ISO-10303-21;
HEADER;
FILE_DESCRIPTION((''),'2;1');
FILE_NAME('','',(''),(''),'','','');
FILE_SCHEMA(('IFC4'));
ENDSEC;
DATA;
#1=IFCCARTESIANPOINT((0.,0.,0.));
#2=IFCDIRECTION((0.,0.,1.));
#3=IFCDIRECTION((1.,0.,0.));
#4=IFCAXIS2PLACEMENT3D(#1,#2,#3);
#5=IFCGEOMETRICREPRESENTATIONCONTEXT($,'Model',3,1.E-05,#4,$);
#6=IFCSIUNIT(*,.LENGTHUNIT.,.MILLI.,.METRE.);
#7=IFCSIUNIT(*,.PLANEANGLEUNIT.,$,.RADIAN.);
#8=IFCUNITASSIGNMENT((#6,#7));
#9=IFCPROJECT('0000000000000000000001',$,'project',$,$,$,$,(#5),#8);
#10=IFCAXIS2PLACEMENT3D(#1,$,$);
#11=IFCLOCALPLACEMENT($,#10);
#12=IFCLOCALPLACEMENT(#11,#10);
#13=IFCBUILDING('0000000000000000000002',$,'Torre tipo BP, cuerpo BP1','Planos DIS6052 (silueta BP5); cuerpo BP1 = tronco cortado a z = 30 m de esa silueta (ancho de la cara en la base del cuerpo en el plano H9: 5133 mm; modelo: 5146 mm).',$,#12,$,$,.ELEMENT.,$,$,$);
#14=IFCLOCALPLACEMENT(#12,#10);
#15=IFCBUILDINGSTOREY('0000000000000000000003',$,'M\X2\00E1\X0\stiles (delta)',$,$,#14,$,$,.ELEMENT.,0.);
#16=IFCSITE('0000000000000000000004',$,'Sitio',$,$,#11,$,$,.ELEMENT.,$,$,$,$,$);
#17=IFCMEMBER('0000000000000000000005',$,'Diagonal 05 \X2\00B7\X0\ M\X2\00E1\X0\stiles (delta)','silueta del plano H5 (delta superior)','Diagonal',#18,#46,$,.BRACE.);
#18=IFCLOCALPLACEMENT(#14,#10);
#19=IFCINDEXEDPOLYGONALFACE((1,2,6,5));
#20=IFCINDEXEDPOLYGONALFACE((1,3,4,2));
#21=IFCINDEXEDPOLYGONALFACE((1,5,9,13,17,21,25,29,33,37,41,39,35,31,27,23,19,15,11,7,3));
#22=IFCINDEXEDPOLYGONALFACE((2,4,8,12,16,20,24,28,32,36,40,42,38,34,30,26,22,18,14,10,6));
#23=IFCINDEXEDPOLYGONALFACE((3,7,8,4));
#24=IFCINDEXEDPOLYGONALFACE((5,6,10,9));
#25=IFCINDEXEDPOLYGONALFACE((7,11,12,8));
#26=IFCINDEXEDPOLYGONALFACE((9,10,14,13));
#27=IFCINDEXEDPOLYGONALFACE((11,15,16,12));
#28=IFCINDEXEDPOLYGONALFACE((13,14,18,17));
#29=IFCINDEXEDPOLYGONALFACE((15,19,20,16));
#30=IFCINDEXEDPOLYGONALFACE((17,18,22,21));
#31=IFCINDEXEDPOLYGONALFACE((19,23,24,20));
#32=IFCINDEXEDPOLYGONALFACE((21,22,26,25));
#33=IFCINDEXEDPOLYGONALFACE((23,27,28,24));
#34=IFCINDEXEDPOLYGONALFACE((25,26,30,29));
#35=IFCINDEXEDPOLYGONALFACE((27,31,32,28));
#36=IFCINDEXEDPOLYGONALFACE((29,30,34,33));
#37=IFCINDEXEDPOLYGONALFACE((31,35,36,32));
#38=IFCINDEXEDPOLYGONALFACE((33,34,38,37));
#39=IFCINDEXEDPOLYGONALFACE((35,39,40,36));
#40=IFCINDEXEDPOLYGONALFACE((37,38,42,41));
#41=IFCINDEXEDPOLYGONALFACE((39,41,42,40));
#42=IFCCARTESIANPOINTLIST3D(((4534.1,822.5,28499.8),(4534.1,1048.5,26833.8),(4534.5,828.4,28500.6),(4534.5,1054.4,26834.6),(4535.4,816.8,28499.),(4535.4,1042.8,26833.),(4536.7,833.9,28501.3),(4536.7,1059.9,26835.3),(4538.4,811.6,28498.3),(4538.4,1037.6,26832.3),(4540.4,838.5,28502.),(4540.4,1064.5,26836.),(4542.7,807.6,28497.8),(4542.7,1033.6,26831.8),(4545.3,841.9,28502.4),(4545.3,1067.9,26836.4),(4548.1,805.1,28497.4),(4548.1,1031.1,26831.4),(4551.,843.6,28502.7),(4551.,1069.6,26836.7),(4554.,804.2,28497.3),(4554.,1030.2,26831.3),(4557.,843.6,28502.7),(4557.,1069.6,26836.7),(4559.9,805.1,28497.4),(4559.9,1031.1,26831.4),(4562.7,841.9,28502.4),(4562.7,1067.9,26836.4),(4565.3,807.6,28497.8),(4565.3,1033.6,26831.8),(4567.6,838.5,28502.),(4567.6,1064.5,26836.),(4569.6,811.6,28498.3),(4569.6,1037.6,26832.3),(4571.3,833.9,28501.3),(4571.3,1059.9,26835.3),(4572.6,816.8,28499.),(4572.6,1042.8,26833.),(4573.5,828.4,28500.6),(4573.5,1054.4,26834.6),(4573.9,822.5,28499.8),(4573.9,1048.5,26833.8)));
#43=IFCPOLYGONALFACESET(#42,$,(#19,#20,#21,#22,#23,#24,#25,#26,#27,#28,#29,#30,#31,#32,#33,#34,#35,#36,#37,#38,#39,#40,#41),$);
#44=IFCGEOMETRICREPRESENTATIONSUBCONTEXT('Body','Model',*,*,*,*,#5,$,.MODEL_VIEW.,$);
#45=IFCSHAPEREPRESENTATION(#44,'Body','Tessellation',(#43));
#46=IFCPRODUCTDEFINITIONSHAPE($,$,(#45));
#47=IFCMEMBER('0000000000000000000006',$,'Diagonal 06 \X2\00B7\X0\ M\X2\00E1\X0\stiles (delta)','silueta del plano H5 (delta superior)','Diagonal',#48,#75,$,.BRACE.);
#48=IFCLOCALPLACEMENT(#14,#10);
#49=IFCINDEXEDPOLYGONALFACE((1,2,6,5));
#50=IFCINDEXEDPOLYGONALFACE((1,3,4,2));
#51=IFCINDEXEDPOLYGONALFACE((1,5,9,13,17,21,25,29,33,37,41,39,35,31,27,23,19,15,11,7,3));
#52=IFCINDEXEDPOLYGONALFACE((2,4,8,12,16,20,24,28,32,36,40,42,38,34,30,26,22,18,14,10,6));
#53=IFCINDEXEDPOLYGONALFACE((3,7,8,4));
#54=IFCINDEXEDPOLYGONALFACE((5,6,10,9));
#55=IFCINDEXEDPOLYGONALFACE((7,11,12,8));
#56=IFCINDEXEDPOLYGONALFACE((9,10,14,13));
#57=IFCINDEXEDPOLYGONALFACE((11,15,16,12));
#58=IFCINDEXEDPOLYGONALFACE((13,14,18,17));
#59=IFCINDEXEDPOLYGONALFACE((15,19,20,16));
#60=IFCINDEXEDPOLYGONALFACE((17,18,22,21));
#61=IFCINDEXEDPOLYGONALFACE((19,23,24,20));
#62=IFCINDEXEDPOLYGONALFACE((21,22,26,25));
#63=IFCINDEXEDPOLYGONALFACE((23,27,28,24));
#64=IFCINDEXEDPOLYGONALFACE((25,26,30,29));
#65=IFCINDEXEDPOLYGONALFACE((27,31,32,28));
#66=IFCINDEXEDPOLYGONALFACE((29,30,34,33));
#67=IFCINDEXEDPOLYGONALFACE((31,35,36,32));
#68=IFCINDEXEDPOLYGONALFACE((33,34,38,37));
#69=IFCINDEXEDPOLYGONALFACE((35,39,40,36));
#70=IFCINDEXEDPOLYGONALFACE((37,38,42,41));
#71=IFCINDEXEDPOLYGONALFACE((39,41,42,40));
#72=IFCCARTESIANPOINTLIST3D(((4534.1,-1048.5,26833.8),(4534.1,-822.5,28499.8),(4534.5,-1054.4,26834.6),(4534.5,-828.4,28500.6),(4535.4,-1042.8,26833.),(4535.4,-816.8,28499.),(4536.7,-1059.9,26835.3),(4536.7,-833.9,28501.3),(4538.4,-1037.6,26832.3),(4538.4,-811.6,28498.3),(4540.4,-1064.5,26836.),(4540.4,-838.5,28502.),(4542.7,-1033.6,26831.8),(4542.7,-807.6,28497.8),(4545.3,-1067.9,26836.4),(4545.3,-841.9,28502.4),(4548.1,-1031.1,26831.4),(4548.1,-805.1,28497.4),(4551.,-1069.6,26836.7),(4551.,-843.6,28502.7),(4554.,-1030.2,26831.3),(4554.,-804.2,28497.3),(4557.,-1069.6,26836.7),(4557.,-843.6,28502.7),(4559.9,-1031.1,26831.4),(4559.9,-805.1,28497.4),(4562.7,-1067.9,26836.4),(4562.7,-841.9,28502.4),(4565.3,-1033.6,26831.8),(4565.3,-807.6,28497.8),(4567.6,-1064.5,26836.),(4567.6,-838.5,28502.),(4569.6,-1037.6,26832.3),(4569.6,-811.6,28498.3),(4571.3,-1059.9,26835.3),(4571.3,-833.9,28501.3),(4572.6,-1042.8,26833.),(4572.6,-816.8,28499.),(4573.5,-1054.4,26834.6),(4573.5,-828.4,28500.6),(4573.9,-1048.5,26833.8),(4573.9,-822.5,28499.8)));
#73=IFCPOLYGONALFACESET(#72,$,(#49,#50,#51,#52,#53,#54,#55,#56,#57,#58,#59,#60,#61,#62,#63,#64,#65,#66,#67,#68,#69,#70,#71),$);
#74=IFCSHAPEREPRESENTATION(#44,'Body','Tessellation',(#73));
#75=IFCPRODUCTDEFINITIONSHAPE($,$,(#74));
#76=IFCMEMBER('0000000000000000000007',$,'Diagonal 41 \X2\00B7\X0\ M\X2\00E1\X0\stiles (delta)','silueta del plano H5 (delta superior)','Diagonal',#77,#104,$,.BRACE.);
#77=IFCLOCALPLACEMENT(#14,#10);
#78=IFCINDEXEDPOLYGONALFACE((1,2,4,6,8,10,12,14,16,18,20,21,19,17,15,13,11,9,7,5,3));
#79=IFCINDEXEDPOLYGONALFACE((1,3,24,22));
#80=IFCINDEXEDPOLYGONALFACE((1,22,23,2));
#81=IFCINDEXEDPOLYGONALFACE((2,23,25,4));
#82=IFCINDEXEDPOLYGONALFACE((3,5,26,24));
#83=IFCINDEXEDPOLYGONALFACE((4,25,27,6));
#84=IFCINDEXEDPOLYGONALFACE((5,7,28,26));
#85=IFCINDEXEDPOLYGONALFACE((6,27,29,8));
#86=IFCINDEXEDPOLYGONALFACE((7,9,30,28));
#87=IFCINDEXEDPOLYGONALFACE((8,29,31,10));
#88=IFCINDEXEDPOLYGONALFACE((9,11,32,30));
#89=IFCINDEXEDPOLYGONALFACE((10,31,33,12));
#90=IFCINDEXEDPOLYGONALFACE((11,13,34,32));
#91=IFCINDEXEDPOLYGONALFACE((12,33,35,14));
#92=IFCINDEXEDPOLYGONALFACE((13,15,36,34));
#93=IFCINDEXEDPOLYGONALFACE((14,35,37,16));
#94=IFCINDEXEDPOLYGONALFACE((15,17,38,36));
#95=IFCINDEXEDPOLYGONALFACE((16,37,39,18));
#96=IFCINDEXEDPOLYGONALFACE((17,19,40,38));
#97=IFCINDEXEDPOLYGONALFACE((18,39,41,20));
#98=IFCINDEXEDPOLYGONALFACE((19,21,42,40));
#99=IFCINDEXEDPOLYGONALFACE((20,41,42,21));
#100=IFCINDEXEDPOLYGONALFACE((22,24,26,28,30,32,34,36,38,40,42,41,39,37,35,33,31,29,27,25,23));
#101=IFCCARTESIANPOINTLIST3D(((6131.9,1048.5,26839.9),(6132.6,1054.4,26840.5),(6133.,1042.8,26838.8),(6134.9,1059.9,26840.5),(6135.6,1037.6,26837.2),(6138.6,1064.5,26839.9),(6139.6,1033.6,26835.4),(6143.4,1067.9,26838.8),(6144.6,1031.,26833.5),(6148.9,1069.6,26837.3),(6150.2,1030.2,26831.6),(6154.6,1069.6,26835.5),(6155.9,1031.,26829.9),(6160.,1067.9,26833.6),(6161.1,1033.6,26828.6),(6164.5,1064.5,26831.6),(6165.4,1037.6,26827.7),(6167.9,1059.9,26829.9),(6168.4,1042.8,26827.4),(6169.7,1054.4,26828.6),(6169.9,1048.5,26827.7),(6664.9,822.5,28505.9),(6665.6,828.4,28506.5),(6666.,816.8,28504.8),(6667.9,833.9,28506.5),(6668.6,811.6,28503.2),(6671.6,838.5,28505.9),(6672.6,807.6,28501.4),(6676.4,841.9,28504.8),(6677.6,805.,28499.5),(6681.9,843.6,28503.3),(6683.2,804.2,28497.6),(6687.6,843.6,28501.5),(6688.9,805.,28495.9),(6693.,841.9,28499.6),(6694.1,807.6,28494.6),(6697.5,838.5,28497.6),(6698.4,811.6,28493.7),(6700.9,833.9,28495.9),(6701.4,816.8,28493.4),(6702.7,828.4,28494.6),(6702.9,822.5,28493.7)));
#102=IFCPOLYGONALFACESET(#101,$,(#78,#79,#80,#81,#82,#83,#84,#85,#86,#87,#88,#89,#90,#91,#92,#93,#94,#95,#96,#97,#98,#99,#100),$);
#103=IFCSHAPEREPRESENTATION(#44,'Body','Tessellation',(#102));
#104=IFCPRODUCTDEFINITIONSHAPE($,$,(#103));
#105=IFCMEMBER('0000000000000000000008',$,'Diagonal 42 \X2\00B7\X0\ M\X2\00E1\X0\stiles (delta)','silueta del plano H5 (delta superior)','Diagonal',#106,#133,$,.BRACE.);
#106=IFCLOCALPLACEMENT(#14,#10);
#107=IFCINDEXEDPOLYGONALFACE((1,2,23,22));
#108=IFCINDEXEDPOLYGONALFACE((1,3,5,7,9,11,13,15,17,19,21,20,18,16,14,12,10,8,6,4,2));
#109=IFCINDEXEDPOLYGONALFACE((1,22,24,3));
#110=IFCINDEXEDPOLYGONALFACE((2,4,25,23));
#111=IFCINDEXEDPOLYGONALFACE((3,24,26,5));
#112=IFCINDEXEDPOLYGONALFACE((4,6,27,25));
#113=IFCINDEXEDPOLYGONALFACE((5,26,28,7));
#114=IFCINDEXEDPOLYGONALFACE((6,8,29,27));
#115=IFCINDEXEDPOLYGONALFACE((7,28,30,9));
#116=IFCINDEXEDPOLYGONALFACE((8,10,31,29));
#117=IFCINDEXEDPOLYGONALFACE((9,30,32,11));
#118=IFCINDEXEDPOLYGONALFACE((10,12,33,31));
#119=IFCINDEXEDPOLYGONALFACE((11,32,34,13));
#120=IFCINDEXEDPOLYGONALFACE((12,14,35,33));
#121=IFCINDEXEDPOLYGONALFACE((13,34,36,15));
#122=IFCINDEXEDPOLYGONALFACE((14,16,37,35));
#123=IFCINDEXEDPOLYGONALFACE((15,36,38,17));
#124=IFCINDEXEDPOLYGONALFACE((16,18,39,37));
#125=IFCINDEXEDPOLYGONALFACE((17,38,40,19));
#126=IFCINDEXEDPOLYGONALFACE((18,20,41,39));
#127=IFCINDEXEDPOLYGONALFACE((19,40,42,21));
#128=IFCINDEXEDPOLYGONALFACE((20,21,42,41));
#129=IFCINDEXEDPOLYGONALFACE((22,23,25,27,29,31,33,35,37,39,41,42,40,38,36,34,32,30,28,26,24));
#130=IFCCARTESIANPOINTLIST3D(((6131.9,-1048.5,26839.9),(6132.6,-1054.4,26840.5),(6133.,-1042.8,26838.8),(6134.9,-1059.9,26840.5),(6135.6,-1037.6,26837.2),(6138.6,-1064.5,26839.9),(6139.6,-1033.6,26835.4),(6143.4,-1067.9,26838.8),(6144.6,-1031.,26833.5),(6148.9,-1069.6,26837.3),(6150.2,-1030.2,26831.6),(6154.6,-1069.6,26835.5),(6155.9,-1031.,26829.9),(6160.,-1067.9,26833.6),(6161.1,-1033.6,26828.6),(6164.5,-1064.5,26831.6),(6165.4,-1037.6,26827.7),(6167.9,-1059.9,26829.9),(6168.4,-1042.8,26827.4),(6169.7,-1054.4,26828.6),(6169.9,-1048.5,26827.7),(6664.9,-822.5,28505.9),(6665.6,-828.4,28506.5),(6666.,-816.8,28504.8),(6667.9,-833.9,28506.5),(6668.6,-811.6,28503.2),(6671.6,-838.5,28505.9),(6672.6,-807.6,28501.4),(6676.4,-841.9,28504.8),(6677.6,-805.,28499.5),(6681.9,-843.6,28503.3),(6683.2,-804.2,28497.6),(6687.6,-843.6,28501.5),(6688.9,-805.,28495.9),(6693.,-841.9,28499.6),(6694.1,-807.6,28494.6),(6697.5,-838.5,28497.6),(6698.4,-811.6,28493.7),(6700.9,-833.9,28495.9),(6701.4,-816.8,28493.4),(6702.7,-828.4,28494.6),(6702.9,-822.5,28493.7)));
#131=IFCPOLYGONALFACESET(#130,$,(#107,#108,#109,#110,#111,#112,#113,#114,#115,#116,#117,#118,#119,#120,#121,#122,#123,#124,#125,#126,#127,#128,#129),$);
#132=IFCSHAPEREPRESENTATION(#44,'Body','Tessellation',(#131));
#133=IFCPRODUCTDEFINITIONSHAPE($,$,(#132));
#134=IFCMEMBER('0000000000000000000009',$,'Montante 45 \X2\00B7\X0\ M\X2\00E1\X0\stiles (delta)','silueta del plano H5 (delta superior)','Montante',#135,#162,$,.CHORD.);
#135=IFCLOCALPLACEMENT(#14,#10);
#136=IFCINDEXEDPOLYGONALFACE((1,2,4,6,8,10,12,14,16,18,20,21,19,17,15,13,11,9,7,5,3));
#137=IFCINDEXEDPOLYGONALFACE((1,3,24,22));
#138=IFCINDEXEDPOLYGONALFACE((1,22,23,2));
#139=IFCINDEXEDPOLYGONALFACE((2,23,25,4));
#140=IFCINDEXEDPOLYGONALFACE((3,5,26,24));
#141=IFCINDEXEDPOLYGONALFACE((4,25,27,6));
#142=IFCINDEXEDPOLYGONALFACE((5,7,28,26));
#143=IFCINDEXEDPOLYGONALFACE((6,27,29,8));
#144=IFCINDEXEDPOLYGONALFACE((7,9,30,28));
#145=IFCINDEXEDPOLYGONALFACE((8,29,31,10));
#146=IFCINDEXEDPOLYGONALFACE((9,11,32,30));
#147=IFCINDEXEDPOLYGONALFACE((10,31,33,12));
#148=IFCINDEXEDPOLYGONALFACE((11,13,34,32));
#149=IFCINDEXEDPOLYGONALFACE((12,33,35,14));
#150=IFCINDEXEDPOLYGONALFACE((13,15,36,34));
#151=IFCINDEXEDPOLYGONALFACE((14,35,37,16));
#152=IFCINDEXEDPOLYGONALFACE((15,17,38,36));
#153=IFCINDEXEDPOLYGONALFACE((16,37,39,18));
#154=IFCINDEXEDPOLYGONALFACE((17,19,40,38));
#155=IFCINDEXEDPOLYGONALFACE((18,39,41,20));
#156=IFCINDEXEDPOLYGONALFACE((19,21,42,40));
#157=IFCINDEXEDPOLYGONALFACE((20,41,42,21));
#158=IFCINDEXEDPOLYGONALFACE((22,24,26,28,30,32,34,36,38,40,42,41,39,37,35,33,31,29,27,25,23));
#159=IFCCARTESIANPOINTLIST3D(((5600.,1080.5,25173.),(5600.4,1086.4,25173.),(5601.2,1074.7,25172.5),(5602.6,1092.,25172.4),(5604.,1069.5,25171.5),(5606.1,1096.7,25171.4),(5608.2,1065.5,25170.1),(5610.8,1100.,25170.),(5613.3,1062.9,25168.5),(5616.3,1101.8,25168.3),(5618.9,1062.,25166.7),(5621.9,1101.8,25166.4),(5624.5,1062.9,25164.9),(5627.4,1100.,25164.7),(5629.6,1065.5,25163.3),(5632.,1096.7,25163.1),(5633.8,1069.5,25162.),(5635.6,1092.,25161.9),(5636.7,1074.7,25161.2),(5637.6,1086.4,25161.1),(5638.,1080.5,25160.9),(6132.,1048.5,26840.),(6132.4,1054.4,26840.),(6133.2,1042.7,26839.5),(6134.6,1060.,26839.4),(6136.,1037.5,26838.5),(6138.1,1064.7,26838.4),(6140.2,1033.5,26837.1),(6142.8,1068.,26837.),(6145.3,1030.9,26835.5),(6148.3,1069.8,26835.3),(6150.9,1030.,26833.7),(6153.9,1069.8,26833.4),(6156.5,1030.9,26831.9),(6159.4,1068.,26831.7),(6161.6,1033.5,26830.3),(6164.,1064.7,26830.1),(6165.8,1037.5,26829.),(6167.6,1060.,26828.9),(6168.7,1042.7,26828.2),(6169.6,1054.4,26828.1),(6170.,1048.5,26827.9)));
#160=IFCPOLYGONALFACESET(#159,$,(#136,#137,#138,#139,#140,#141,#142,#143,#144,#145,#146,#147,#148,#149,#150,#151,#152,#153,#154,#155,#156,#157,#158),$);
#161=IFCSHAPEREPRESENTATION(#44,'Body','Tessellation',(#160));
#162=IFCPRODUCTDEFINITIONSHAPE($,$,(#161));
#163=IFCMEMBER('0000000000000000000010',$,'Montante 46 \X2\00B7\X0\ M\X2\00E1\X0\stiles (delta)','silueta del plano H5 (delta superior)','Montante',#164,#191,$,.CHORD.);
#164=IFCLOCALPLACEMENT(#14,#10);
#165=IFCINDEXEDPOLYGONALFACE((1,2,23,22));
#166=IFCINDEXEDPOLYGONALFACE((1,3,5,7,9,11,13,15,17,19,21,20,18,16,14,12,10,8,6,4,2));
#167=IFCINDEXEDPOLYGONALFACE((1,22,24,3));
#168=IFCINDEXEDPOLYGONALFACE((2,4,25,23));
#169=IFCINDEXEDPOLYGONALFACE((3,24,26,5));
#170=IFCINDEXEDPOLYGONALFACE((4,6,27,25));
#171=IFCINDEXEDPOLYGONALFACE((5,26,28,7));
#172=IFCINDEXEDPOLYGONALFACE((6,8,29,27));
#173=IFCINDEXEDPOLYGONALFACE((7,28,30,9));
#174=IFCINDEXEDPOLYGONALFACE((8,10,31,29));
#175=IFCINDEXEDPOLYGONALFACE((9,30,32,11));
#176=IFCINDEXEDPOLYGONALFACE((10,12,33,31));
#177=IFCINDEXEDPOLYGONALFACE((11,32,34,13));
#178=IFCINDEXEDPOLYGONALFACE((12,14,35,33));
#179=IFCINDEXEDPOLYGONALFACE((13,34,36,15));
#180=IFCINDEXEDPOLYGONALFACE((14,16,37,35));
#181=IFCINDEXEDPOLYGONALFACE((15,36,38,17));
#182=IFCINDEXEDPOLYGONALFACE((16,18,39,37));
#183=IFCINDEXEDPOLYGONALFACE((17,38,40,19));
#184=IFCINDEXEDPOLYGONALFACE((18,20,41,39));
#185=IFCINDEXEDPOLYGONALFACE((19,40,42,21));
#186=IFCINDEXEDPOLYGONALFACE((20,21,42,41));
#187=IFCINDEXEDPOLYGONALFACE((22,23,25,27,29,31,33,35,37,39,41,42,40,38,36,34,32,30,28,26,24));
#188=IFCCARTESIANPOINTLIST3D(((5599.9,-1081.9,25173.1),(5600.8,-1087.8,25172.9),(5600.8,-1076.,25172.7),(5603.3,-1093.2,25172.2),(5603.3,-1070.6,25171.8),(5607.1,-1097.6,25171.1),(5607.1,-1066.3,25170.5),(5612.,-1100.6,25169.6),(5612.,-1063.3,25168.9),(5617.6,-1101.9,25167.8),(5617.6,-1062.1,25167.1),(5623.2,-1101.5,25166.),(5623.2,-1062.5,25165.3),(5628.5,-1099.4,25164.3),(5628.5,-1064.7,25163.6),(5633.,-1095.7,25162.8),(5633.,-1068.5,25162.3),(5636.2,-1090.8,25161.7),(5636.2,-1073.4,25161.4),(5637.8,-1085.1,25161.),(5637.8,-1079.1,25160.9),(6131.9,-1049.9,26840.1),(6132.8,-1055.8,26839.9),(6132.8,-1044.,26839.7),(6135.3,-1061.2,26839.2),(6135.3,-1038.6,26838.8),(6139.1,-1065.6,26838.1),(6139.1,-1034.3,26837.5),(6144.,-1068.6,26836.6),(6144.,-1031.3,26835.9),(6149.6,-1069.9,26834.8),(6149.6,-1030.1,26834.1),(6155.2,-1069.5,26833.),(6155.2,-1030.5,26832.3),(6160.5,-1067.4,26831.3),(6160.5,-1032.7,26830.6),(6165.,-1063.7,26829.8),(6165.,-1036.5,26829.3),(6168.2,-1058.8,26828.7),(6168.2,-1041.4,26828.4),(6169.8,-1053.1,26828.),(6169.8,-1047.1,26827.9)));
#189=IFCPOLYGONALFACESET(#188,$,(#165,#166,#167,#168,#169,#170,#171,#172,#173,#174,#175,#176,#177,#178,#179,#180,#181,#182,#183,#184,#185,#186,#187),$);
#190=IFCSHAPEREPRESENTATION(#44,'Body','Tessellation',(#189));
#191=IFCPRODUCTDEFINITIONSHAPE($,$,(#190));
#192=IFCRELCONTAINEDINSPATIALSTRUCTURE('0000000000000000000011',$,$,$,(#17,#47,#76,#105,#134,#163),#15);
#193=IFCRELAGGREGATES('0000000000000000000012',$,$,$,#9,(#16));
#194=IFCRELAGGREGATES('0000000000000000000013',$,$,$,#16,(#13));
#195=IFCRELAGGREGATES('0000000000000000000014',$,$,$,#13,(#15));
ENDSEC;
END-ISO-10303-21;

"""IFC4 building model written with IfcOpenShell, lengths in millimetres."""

from ifc_helpers import new_model, si_unit, frame, origin, origin_with_axes, place, context, subcontext, project, spatial, circle, extrude, element, save


model = new_model("IFC4")

# Units and contexts
model_context = context("Model", 3, precision=1e-05, world=origin_with_axes())
body_context = subcontext(model_context, "Body", "Model", "MODEL_VIEW")
ifc_project = project(units=[si_unit("LENGTHUNIT", "METRE", prefix="MILLI"), si_unit("PLANEANGLEUNIT", "RADIAN")], contexts=[model_context])

# Site, building, storey
site_placement = place(None, origin())
site = spatial("IfcSite", under=ifc_project, at=site_placement, Name="Sitio", CompositionType="ELEMENT")
building_placement = place(site_placement, origin())
building = spatial("IfcBuilding", under=site, at=building_placement, Name="Torre tipo BP, cuerpo BP1", Description="Planos DIS6052 (silueta BP5); cuerpo BP1 = tronco cortado a z = 30 m de esa silueta (ancho de la cara en la base del cuerpo en el plano H9: 5133 mm; modelo: 5146 mm).", CompositionType="ELEMENT")
storey_placement = place(building_placement, origin())
storey = spatial("IfcBuildingStorey", under=building, at=storey_placement, Name="Mástiles (delta)", CompositionType="ELEMENT", Elevation=0.0)

# Members
for number, where, z_axis, x_axis, name in (
    (1, (4554.0, 824.0, 28500.0), (0.0, 0.134423, -0.990924), (0.0, -0.990924, -0.134423), "Diagonal 05 · Mástiles (delta)"),
    (2, (4554.0, -824.0, 28500.0), (0.0, -0.134423, -0.990924), (0.0, 0.990924, -0.134423), "Diagonal 06 · Mástiles (delta)"),
):
    element("IfcMember", number, at=place(storey_placement, frame(where, z_axis=z_axis, x_axis=x_axis)), inside=storey, Name=name, Description="silueta del plano H5 (delta superior)", ObjectType="Diagonal", PredefinedType="BRACE", context=body_context, shape_type="SweptSolid", body=[
        extrude(circle(Radius=20.0), None, (0.0, 0.0, 1.0), 1681.3),
    ])
for number, where, z_axis, x_axis, name in (
    (3, (6684.0, 824.0, 28500.0), (-0.302202, 0.128138, -0.944592), (-0.039045, -0.991756, -0.122044), "Diagonal 41 · Mástiles (delta)"),
    (4, (6684.0, -824.0, 28500.0), (-0.302202, -0.128138, -0.944592), (-0.039045, 0.991756, -0.122044), "Diagonal 42 · Mástiles (delta)"),
):
    element("IfcMember", number, at=place(storey_placement, frame(where, z_axis=z_axis, x_axis=x_axis)), inside=storey, Name=name, Description="silueta del plano H5 (delta superior)", ObjectType="Diagonal", PredefinedType="BRACE", context=body_context, shape_type="SweptSolid", body=[
        extrude(circle(Radius=20.0), None, (0.0, 0.0, 1.0), 1763.7),
    ])
for number, where, z_axis, x_axis, name in (
    (5, (6151.0, 1050.0, 26834.0), (-0.303978, 0.018284, -0.952503), (-0.005559, -0.999833, -0.017419), "Montante 45 · Mástiles (delta)"),
    (6, (6151.0, -1050.0, 26834.0), (-0.303978, -0.018284, -0.952503), (-0.952679, 0.005834, 0.303922), "Montante 46 · Mástiles (delta)"),
):
    element("IfcMember", number, at=place(storey_placement, frame(where, z_axis=z_axis, x_axis=x_axis)), inside=storey, Name=name, Description="silueta del plano H5 (delta superior)", ObjectType="Montante", PredefinedType="CHORD", context=body_context, shape_type="SweptSolid", body=[
        extrude(circle(Radius=20.0), None, (0.0, 0.0, 1.0), 1750.1),
    ])

save(model, "model.ifc")
